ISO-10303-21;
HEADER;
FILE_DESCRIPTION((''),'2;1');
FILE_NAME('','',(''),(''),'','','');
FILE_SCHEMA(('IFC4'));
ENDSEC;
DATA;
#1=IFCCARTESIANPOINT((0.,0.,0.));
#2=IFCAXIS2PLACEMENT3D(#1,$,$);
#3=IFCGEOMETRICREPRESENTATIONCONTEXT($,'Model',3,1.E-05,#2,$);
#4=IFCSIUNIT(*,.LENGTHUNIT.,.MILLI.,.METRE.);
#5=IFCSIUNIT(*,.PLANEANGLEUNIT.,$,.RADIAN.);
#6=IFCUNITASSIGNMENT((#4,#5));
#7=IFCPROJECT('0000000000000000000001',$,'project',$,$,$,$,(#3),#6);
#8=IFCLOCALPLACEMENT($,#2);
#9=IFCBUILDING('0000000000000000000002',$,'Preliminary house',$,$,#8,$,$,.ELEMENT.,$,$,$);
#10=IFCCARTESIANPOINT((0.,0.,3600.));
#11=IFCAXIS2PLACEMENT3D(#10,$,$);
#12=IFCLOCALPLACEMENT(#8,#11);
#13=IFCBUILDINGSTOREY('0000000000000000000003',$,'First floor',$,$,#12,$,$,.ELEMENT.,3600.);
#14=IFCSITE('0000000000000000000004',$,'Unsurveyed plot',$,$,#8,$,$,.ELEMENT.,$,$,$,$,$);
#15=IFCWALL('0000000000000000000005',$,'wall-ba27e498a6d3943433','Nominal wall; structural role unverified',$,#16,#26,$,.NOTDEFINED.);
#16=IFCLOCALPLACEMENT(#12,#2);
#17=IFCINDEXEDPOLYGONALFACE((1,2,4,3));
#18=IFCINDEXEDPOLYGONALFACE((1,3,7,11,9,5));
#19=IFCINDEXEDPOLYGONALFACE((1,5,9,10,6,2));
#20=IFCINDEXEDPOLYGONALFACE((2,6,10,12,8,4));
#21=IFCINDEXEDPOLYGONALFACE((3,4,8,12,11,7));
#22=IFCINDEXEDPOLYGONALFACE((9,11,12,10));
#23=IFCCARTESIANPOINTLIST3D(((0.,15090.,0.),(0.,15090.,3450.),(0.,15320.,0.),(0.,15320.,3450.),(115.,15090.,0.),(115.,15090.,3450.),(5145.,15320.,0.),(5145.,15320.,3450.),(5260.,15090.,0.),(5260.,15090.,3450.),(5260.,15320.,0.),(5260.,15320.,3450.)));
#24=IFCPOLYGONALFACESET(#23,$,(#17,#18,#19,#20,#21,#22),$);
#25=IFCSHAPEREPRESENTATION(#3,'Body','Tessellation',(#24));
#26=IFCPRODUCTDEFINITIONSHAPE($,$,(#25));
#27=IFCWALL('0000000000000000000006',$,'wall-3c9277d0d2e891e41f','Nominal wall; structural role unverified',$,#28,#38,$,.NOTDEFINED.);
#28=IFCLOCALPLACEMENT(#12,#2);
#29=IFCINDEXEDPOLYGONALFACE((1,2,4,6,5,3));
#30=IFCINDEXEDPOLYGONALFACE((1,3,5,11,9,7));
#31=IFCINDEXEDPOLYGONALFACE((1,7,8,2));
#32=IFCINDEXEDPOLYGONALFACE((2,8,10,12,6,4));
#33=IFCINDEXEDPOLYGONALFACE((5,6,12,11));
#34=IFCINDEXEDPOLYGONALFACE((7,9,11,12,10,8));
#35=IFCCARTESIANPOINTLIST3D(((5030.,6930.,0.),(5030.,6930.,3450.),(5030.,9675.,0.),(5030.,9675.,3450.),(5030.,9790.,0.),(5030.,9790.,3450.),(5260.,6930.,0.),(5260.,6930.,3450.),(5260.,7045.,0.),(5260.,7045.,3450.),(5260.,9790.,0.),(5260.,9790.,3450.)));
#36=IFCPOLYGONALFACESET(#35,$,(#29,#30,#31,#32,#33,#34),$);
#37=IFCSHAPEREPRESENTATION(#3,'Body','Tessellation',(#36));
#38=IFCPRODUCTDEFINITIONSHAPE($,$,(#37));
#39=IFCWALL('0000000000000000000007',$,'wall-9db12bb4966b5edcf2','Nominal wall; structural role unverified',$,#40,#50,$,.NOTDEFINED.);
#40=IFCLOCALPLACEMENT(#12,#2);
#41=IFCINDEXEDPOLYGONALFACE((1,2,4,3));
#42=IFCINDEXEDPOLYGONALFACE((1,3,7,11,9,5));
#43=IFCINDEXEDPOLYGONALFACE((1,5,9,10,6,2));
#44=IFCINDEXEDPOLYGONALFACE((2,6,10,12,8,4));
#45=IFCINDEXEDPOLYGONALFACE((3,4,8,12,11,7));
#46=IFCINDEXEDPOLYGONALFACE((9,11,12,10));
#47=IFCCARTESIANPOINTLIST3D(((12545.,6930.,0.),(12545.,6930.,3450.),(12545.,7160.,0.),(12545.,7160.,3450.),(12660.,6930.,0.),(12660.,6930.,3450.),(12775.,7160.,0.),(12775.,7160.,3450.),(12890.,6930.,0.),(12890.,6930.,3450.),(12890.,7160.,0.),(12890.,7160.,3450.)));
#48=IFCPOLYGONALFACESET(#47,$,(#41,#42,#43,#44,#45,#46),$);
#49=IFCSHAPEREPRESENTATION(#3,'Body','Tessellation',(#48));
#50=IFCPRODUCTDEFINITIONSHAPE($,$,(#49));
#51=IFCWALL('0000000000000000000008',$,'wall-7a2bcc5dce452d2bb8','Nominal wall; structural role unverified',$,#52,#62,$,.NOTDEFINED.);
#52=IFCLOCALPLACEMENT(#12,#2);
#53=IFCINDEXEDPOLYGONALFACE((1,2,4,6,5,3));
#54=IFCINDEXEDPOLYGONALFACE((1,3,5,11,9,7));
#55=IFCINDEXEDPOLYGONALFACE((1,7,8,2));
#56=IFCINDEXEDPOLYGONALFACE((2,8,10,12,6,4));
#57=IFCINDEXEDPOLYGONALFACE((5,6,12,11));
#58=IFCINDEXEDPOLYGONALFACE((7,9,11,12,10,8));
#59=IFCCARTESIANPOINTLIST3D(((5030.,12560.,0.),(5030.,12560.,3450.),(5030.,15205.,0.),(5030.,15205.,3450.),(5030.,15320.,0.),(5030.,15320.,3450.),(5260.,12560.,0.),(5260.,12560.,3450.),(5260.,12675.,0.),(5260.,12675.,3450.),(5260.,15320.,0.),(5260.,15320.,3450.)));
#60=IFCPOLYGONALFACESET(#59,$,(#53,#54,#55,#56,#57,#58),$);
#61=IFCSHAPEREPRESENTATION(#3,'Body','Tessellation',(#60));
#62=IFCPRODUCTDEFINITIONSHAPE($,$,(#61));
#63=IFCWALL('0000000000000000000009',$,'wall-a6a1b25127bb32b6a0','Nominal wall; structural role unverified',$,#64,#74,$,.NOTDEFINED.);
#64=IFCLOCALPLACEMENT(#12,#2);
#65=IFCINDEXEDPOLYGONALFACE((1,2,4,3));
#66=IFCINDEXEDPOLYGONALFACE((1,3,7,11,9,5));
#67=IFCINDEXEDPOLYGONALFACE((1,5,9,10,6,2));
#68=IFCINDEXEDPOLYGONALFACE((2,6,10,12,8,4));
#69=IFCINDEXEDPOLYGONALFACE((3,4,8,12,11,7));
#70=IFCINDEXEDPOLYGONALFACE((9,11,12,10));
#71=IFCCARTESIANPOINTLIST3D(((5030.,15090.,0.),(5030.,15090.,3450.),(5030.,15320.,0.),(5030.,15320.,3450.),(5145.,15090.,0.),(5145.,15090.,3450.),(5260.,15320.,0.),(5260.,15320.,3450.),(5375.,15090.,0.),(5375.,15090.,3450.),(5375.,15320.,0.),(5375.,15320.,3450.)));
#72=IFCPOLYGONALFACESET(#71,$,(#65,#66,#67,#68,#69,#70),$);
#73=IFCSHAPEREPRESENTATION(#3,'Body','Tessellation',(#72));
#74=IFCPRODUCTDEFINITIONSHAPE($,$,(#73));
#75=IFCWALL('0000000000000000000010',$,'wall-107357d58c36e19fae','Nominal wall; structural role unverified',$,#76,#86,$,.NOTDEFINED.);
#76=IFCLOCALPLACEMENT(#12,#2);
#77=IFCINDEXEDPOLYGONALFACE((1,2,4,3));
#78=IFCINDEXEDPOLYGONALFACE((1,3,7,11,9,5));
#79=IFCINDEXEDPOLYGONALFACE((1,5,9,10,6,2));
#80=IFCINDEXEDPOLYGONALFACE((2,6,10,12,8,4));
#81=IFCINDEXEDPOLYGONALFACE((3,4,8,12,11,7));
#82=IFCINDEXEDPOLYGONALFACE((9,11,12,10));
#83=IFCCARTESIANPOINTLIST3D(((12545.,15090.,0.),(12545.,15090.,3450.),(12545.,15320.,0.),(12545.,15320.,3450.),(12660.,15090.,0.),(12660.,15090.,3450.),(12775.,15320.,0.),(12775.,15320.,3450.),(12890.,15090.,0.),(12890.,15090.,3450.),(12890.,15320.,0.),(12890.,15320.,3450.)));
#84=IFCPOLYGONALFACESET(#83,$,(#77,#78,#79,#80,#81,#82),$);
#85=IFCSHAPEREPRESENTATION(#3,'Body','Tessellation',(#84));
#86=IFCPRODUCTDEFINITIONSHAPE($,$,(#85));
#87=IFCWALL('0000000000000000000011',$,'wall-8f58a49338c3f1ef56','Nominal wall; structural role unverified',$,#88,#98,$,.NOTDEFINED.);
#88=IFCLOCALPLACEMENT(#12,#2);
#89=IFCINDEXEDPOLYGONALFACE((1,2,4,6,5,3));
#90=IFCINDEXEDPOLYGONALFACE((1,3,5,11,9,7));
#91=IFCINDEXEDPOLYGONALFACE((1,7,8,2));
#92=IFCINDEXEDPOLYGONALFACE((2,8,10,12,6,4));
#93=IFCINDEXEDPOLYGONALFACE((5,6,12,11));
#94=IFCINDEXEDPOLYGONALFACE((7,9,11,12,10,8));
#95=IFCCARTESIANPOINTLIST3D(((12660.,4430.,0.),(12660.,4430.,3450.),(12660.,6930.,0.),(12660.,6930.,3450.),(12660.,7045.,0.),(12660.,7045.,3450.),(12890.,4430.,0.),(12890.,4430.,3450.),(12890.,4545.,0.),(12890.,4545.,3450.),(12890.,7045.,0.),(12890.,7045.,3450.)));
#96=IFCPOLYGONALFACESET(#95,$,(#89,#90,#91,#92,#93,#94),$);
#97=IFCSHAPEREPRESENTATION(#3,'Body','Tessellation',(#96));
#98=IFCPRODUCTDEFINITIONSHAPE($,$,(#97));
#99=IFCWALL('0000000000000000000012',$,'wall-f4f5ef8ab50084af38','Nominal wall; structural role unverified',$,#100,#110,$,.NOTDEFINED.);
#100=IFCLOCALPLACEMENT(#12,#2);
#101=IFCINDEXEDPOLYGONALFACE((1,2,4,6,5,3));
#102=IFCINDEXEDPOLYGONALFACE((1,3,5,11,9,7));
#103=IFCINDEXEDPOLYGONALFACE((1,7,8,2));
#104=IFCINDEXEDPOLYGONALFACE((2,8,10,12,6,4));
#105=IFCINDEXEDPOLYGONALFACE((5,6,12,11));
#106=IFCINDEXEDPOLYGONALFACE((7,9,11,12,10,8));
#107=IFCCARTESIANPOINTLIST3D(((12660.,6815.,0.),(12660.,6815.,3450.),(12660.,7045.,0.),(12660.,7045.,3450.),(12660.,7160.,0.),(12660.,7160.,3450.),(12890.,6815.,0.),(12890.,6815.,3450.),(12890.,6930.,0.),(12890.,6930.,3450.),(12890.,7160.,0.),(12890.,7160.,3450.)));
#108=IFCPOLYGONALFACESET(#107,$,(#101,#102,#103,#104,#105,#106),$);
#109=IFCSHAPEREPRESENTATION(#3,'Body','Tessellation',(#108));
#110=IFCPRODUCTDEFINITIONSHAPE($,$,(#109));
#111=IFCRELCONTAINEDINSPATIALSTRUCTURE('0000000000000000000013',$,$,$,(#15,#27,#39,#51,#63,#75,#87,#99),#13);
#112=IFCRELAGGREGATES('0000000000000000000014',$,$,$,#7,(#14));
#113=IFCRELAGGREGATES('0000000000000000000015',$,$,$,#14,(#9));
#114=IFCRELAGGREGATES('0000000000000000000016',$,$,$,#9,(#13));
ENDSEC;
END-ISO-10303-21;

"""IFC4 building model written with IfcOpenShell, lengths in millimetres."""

from ifc_helpers import new_model, si_unit, frame, origin, place, context, project, spatial, polyline, outline, extrude, element, save


model = new_model("IFC4")

# Units and contexts
model_context = context("Model", 3, precision=1e-05, world=origin())
ifc_project = project(units=[si_unit("LENGTHUNIT", "METRE", prefix="MILLI"), si_unit("PLANEANGLEUNIT", "RADIAN")], contexts=[model_context])

# Site, building, storey
placement_1 = place(None, origin())
site = spatial("IfcSite", under=ifc_project, at=placement_1, Name="Unsurveyed plot", CompositionType="ELEMENT")
building = spatial("IfcBuilding", under=site, at=placement_1, Name="Preliminary house", CompositionType="ELEMENT")
placement_2 = place(placement_1, frame((0.0, 0.0, 3600.0)))
storey = spatial("IfcBuildingStorey", under=building, at=placement_2, Name="First floor", CompositionType="ELEMENT", Elevation=3600.0)

# Walls
element("IfcWall", 1, at=placement_2, inside=storey, Name="wall-ba27e498a6d3943433", Description="Nominal wall; structural role unverified", PredefinedType="NOTDEFINED", context=model_context, shape_type="SweptSolid", body=[
    extrude(outline(polyline([(5145.0, 15320.0), (5260.0, 15320.0), (5260.0, 15090.0), (115.0, 15090.0), (0.0, 15090.0), (0.0, 15320.0), (5145.0, 15320.0)])), origin(), (0.0, 0.0, 1.0), 3450.0),
])
element("IfcWall", 2, at=placement_2, inside=storey, Name="wall-3c9277d0d2e891e41f", Description="Nominal wall; structural role unverified", PredefinedType="NOTDEFINED", context=model_context, shape_type="SweptSolid", body=[
    extrude(outline(polyline([(5030.0, 9675.0), (5030.0, 9790.0), (5260.0, 9790.0), (5260.0, 7045.0), (5260.0, 6930.0), (5030.0, 6930.0), (5030.0, 9675.0)])), origin(), (0.0, 0.0, 1.0), 3450.0),
])

# Wall
element("IfcWall", 3, at=placement_2, inside=storey, Name="wall-9db12bb4966b5edcf2", Description="Nominal wall; structural role unverified", PredefinedType="NOTDEFINED", context=model_context, shape_type="SweptSolid", body=[
    extrude(outline(polyline([(12775.0, 7160.0), (12890.0, 7160.0), (12890.0, 6930.0), (12660.0, 6930.0), (12545.0, 6930.0), (12545.0, 7160.0), (12775.0, 7160.0)])), origin(), (0.0, 0.0, 1.0), 3450.0),
])

# Walls
element("IfcWall", 4, at=placement_2, inside=storey, Name="wall-7a2bcc5dce452d2bb8", Description="Nominal wall; structural role unverified", PredefinedType="NOTDEFINED", context=model_context, shape_type="SweptSolid", body=[
    extrude(outline(polyline([(5030.0, 15205.0), (5030.0, 15320.0), (5260.0, 15320.0), (5260.0, 12675.0), (5260.0, 12560.0), (5030.0, 12560.0), (5030.0, 15205.0)])), origin(), (0.0, 0.0, 1.0), 3450.0),
])
element("IfcWall", 5, at=placement_2, inside=storey, Name="wall-a6a1b25127bb32b6a0", Description="Nominal wall; structural role unverified", PredefinedType="NOTDEFINED", context=model_context, shape_type="SweptSolid", body=[
    extrude(outline(polyline([(5260.0, 15320.0), (5375.0, 15320.0), (5375.0, 15090.0), (5145.0, 15090.0), (5030.0, 15090.0), (5030.0, 15320.0), (5260.0, 15320.0)])), origin(), (0.0, 0.0, 1.0), 3450.0),
])

# Walls
element("IfcWall", 6, at=placement_2, inside=storey, Name="wall-107357d58c36e19fae", Description="Nominal wall; structural role unverified", PredefinedType="NOTDEFINED", context=model_context, shape_type="SweptSolid", body=[
    extrude(outline(polyline([(12775.0, 15320.0), (12890.0, 15320.0), (12890.0, 15090.0), (12660.0, 15090.0), (12545.0, 15090.0), (12545.0, 15320.0), (12775.0, 15320.0)])), origin(), (0.0, 0.0, 1.0), 3450.0),
])
element("IfcWall", 7, at=placement_2, inside=storey, Name="wall-8f58a49338c3f1ef56", Description="Nominal wall; structural role unverified", PredefinedType="NOTDEFINED", context=model_context, shape_type="SweptSolid", body=[
    extrude(outline(polyline([(12660.0, 6930.0), (12660.0, 7045.0), (12890.0, 7045.0), (12890.0, 4545.0), (12890.0, 4430.0), (12660.0, 4430.0), (12660.0, 6930.0)])), origin(), (0.0, 0.0, 1.0), 3450.0),
])
element("IfcWall", 8, at=placement_2, inside=storey, Name="wall-f4f5ef8ab50084af38", Description="Nominal wall; structural role unverified", PredefinedType="NOTDEFINED", context=model_context, shape_type="SweptSolid", body=[
    extrude(outline(polyline([(12660.0, 7045.0), (12660.0, 7160.0), (12890.0, 7160.0), (12890.0, 6930.0), (12890.0, 6815.0), (12660.0, 6815.0), (12660.0, 7045.0)])), origin(), (0.0, 0.0, 1.0), 3450.0),
])

save(model, "model.ifc")
